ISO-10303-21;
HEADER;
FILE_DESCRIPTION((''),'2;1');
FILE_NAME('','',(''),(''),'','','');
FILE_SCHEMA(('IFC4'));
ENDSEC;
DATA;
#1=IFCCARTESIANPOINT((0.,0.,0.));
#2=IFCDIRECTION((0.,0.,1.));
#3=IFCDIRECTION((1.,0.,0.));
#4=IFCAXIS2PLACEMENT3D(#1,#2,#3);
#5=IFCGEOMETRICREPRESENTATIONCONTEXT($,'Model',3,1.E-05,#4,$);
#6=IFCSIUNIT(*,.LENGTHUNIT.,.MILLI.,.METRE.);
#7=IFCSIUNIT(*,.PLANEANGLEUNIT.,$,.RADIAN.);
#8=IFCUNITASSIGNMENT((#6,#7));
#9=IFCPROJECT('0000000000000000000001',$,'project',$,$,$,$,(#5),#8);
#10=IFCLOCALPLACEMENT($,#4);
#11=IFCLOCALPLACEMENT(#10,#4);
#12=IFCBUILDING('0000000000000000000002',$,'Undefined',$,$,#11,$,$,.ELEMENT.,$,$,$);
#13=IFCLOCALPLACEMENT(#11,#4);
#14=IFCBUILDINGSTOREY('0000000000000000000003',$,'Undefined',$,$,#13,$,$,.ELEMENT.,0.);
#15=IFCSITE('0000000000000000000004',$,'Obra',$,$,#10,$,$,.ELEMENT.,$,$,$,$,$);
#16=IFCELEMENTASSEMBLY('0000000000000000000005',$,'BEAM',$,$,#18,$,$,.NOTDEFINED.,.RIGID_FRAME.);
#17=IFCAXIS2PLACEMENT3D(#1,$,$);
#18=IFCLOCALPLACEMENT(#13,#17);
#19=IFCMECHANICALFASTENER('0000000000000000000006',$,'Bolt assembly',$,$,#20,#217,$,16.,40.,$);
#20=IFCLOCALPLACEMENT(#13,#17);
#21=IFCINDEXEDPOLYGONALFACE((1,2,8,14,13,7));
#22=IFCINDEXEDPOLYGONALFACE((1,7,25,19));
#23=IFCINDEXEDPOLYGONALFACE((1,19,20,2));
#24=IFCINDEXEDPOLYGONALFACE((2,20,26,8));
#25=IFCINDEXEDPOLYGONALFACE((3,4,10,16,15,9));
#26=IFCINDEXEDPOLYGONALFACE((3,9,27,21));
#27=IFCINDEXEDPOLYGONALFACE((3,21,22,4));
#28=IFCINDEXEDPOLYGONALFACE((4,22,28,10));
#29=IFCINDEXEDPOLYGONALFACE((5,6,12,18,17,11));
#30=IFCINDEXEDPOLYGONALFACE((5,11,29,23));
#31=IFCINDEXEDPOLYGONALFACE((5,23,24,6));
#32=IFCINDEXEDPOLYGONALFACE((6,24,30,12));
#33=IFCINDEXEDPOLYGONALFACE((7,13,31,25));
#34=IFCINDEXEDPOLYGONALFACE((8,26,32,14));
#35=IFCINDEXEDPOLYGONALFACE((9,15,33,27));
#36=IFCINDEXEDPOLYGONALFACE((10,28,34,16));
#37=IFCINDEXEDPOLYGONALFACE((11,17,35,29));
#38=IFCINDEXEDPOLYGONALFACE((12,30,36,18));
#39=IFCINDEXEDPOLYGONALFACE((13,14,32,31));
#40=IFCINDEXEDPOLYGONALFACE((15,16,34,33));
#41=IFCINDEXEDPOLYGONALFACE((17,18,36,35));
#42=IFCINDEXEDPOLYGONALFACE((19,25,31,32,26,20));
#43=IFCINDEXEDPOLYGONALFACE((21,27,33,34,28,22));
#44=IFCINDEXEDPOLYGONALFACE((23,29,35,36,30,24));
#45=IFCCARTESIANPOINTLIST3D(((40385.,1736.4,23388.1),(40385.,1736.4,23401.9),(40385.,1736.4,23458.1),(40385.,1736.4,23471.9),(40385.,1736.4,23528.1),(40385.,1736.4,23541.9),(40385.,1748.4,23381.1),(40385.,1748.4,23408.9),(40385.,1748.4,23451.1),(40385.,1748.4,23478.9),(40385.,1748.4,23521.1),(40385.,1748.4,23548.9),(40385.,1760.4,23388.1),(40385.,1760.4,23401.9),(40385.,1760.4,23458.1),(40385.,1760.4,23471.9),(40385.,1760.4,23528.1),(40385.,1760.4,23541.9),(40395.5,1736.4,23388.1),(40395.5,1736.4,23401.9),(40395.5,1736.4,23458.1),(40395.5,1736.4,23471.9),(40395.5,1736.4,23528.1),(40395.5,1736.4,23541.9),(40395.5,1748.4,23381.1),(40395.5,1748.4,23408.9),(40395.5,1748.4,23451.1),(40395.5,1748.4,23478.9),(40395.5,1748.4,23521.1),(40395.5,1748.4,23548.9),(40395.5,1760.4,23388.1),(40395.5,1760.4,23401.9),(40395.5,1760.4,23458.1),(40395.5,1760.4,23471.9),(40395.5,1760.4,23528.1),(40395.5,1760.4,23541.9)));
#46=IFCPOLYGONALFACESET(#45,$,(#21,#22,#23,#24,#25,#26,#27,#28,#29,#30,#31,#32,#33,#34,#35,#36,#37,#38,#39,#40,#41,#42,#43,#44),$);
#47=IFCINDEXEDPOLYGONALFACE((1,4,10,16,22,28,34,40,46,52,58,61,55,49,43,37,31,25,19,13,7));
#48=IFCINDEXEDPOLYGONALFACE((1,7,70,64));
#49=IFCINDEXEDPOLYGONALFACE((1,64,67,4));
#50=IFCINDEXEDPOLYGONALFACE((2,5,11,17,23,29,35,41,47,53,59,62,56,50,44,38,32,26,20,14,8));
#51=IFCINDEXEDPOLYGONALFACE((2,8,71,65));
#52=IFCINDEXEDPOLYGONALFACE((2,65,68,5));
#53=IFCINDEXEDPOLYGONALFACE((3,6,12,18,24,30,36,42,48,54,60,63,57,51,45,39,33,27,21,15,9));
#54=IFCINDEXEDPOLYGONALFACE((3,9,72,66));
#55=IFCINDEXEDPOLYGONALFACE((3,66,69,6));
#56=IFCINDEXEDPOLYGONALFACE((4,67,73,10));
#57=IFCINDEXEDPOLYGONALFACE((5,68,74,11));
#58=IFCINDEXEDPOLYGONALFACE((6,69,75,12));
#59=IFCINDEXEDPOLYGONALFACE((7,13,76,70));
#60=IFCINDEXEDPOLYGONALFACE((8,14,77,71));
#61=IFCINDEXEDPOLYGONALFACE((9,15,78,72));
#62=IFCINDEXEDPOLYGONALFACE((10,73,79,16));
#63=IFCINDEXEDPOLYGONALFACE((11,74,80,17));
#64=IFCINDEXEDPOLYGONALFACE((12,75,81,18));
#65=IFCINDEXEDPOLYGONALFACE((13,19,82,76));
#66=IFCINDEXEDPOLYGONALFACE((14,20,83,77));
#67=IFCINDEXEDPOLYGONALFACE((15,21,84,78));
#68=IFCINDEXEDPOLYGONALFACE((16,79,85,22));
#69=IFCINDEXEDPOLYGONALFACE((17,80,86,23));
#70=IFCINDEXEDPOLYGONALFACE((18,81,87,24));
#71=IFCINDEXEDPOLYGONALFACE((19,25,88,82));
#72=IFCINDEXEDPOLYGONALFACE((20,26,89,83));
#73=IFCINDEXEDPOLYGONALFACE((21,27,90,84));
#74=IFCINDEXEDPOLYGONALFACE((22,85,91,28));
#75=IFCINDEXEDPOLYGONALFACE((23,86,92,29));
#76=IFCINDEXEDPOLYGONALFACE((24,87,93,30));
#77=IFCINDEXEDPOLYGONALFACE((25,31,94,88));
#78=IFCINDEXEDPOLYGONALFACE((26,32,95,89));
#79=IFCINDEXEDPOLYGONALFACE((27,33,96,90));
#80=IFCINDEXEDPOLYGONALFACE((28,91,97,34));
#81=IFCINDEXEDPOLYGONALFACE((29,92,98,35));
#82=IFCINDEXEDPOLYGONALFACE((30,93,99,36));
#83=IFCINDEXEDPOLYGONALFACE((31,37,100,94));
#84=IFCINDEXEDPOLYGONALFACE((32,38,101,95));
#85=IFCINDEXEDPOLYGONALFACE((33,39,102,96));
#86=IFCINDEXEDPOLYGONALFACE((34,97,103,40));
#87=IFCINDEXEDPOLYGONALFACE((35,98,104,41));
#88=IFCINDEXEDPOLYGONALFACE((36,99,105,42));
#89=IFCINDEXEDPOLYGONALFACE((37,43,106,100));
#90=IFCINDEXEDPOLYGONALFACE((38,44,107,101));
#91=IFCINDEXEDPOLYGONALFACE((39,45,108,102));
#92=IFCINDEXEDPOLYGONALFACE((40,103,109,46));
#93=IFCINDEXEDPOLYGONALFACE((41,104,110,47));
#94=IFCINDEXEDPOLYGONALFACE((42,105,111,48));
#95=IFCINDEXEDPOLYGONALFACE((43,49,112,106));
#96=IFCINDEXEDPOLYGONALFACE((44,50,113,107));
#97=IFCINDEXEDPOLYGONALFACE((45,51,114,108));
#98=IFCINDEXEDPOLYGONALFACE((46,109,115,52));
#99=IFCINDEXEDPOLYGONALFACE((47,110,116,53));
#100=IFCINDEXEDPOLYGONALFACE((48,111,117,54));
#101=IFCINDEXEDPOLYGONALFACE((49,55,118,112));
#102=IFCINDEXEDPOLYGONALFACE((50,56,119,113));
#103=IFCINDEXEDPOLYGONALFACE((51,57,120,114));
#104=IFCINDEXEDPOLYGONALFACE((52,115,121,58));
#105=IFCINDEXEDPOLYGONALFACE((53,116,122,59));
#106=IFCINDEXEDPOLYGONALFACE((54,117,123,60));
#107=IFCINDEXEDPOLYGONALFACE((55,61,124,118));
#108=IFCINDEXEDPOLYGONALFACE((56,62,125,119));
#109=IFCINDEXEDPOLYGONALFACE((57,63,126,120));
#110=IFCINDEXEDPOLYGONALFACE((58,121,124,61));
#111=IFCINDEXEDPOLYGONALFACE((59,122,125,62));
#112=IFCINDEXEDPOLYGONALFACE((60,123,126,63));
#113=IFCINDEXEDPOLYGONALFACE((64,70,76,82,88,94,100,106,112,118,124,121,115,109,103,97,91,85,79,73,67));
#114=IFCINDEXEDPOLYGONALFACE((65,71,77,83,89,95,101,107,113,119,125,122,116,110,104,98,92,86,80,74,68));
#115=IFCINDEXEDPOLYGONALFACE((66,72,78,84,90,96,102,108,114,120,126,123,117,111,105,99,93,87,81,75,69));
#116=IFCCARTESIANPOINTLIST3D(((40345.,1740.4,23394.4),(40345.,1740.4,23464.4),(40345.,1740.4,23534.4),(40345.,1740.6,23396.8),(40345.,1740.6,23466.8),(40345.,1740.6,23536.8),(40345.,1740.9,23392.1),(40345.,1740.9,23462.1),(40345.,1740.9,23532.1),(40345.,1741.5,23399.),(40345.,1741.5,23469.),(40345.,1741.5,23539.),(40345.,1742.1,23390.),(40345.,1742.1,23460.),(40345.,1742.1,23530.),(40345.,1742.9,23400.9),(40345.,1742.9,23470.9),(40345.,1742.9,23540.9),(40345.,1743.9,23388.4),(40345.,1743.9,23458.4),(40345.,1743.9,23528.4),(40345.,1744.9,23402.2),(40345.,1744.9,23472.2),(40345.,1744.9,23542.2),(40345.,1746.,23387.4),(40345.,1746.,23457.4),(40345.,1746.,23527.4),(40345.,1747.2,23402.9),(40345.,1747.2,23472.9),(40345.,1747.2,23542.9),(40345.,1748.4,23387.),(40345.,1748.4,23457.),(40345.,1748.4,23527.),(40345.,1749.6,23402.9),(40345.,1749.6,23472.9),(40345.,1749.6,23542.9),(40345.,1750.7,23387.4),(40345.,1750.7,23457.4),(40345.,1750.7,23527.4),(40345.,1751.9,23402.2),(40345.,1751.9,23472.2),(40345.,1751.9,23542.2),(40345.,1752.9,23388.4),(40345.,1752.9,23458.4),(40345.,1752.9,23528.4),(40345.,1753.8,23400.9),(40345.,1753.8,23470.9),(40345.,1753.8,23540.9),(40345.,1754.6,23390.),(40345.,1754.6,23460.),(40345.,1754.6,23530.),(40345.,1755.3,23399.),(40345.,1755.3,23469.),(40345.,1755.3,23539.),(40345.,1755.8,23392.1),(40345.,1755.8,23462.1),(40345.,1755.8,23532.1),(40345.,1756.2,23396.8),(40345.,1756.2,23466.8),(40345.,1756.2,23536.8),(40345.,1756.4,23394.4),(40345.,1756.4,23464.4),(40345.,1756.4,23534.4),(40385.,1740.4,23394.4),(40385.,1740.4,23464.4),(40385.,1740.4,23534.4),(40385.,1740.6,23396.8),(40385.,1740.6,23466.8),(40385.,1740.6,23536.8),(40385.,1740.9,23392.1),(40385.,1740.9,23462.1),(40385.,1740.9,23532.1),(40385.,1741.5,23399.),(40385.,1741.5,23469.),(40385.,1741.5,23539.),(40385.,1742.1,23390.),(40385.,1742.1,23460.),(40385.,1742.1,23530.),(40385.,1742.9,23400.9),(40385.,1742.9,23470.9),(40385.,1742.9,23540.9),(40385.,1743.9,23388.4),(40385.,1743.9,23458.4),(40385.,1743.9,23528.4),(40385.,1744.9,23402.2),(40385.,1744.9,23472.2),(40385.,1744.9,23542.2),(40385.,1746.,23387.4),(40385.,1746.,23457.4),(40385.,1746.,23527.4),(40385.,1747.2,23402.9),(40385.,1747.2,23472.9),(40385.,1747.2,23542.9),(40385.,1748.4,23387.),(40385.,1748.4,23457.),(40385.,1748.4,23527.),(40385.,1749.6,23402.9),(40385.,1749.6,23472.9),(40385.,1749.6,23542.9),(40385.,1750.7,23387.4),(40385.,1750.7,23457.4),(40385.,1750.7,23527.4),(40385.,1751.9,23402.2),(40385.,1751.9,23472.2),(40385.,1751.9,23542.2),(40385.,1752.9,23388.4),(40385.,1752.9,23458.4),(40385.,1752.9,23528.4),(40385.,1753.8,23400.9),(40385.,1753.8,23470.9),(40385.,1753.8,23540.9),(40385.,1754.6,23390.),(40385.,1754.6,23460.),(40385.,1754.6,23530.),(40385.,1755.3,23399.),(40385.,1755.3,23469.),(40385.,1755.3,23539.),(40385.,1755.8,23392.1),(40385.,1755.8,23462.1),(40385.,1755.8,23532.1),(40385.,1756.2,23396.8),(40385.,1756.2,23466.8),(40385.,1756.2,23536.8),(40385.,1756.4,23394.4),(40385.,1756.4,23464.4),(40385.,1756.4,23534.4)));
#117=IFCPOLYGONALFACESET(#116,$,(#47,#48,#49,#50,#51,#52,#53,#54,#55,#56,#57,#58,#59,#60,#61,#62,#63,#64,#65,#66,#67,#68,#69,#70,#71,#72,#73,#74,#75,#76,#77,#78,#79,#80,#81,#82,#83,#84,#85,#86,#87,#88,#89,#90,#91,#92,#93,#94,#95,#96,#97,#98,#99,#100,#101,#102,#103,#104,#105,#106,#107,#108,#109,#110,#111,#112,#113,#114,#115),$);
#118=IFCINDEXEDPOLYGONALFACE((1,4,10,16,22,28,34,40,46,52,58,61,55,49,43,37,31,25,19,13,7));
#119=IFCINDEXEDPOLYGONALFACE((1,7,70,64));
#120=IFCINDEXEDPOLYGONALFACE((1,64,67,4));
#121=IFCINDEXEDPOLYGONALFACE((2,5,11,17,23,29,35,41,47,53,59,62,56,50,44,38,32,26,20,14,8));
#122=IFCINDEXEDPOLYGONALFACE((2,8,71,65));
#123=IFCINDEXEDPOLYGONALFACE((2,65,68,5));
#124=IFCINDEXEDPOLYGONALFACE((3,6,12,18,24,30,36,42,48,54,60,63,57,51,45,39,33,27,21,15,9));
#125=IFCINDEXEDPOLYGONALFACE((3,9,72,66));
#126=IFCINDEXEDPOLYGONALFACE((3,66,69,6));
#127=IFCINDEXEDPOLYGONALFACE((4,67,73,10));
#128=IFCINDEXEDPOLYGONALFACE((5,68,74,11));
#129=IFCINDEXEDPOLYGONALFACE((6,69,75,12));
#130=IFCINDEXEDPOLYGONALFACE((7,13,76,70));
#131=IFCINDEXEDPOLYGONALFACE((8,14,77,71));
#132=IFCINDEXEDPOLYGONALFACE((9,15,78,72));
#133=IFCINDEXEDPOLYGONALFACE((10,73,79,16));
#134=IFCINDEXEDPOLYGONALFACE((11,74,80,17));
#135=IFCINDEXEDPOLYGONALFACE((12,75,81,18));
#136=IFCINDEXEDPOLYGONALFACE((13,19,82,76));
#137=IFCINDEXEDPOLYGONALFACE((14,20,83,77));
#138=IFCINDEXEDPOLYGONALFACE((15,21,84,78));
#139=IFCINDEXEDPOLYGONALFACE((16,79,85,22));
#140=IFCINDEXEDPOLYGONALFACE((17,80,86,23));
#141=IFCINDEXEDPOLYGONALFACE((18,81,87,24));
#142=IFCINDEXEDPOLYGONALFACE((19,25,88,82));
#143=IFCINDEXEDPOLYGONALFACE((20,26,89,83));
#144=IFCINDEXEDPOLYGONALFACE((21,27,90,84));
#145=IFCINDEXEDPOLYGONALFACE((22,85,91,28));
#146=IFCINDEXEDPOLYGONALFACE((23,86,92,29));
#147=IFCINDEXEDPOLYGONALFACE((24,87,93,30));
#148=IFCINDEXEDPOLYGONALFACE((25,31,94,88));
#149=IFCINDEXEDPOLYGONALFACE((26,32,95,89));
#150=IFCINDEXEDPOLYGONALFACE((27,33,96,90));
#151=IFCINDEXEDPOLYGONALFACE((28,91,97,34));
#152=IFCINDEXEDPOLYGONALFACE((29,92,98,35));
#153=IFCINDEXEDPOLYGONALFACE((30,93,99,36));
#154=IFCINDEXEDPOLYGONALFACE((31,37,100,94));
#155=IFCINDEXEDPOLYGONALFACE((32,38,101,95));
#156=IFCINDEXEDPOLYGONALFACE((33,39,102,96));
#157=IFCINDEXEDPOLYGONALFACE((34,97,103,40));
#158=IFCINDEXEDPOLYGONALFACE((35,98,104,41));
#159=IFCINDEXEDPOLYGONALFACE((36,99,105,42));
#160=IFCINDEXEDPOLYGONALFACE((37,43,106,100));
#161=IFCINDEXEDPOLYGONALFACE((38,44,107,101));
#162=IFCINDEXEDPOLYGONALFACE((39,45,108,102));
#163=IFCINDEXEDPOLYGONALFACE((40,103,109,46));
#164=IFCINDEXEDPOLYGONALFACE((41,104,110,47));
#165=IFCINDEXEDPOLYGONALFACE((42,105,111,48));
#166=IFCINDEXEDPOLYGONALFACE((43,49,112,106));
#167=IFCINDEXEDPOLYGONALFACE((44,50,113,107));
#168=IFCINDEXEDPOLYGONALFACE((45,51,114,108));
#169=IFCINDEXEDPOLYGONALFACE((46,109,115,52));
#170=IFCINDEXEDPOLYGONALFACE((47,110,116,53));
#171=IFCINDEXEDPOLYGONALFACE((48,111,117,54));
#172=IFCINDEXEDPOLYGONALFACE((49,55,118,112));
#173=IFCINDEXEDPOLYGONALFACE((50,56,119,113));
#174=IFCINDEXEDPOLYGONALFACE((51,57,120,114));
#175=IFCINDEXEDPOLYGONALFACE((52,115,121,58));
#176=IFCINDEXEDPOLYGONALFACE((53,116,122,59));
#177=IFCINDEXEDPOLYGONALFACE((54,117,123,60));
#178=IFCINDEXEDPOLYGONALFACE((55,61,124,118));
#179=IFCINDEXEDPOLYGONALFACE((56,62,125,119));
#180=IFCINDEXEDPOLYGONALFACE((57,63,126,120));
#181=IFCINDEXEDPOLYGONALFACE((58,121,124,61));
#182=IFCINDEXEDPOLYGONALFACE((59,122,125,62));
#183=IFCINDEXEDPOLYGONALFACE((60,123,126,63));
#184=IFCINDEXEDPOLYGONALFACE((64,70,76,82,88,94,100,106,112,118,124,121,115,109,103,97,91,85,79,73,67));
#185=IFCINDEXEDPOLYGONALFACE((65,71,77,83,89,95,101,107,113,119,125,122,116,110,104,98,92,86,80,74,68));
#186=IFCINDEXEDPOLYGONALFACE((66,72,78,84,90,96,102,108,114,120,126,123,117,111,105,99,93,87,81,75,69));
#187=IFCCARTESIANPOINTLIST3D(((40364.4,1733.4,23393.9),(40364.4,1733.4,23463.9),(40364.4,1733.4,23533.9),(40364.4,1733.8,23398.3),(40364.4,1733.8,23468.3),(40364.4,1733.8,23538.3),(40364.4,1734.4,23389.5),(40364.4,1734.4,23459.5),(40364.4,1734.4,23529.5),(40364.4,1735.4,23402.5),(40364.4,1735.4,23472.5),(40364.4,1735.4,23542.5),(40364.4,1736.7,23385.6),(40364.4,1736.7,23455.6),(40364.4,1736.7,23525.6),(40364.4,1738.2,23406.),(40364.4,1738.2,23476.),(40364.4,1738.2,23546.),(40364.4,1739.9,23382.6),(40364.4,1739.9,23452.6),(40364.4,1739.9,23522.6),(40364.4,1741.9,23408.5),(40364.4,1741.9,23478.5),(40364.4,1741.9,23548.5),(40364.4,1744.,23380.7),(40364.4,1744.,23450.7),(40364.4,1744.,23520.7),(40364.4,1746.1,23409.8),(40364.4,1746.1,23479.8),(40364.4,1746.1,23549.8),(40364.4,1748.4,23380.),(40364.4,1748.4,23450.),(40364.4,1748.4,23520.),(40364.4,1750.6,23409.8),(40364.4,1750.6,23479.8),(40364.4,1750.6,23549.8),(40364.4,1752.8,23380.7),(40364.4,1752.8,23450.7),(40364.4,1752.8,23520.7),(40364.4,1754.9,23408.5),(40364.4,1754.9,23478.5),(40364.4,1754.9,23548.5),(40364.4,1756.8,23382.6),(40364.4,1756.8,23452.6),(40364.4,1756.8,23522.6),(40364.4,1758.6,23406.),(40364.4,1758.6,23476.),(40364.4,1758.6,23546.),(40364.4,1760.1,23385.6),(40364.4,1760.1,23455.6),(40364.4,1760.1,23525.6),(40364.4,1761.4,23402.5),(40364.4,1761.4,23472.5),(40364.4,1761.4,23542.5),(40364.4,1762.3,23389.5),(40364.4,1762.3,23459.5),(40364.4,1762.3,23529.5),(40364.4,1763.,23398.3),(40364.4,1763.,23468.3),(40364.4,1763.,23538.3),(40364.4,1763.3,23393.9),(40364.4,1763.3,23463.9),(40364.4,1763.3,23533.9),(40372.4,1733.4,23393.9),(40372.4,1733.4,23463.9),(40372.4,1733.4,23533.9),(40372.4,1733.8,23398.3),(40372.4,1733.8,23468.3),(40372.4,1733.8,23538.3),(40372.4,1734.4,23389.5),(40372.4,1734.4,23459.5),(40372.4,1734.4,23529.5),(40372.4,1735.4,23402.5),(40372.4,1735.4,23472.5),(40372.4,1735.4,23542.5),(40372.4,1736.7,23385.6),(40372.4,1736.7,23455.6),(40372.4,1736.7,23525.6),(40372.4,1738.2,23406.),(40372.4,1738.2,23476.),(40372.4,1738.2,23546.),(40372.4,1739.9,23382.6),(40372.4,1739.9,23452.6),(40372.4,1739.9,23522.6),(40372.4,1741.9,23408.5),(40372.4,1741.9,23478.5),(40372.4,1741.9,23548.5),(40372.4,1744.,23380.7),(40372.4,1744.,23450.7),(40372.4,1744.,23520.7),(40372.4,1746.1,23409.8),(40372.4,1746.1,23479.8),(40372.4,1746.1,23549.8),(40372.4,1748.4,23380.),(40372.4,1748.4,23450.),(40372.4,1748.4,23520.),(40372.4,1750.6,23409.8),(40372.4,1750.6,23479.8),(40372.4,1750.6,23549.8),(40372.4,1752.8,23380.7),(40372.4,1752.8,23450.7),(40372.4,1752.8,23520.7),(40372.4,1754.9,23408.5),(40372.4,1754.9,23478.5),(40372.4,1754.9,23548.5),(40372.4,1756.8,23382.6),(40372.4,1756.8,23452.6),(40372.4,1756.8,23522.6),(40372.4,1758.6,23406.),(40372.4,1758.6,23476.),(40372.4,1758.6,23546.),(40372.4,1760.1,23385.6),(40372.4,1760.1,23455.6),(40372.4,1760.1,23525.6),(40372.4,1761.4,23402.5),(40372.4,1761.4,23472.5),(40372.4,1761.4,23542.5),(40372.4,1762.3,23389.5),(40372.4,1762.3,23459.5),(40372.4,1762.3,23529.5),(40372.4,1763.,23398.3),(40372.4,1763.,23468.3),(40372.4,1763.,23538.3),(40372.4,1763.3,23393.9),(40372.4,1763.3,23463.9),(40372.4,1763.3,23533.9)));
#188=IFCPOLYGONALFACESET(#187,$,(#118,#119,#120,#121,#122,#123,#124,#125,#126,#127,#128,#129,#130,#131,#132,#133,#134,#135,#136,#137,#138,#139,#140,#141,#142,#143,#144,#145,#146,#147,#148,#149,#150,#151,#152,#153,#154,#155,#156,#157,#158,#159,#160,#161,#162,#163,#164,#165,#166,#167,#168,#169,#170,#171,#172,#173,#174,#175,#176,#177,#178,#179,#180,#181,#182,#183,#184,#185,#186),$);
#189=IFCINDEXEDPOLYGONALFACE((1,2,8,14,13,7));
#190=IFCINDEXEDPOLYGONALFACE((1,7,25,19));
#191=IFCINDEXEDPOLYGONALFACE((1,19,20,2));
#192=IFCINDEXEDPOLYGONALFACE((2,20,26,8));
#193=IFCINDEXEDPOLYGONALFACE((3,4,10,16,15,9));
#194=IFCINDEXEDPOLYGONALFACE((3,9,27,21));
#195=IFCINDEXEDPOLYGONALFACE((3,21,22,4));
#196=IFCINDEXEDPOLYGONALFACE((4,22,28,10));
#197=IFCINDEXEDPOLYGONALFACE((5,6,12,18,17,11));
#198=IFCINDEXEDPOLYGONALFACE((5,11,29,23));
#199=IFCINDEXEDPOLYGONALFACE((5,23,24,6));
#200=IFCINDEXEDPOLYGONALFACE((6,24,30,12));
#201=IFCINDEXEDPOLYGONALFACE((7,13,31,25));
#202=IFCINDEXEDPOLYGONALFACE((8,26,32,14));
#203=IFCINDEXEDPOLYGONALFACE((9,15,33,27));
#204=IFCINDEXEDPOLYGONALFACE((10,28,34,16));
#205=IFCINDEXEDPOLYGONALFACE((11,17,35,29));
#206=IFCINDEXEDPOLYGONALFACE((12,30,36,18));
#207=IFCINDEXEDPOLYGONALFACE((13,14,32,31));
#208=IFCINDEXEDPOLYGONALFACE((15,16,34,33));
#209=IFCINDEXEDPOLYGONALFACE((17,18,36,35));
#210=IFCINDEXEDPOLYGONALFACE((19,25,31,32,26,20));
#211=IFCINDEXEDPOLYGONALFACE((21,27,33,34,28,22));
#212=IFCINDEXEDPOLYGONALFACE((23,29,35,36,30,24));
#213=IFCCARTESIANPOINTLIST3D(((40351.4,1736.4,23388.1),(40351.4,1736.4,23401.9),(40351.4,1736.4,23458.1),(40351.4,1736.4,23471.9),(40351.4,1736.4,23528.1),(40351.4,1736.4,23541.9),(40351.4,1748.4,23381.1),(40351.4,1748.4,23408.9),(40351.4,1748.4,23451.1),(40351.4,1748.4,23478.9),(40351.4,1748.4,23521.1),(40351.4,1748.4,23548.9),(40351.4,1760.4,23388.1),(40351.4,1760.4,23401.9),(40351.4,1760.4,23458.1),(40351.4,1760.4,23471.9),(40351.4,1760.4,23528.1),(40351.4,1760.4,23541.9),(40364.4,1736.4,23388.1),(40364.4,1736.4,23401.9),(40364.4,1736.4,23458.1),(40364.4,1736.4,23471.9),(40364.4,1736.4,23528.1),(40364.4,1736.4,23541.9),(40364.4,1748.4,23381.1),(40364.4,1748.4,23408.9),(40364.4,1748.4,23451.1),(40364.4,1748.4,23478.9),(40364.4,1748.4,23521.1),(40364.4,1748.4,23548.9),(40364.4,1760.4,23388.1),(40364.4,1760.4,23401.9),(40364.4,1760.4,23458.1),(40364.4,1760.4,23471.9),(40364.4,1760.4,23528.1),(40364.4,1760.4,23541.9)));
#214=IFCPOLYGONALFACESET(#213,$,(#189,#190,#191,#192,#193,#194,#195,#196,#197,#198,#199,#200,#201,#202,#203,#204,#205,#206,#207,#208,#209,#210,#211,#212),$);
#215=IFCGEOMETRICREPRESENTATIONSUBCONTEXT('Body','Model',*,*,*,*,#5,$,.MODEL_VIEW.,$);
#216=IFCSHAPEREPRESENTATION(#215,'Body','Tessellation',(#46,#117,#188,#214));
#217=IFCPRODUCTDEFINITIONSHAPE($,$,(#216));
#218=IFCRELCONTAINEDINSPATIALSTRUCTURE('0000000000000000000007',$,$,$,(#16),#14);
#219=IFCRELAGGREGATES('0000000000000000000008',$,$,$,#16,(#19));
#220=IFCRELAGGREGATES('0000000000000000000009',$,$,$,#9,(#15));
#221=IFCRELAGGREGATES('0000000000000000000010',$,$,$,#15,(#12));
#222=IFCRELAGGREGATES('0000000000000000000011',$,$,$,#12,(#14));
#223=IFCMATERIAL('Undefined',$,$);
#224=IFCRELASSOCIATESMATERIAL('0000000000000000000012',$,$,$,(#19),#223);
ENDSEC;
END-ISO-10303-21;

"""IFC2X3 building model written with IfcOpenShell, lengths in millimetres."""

from ifc_helpers import new_model, si_unit, frame, origin_with_axes, origin_2d_with_axis, place, context, subcontext, project, spatial, polyline, circle, outline, extrude, source, transform, mapped, material, element, aggregate, save


model = new_model("IFC2X3")

# Units and contexts
model_context = context("Model", 3, precision=1e-05, world=origin_with_axes())
body_context = subcontext(model_context, "Body", "Model", "MODEL_VIEW")
ifc_project = project(units=[si_unit("LENGTHUNIT", "METRE", prefix="MILLI"), si_unit("PLANEANGLEUNIT", "RADIAN")], contexts=[model_context])

# Site, building, storey
site_placement = place(None, origin_with_axes())
site = spatial("IfcSite", under=ifc_project, at=site_placement, Name="Obra", CompositionType="ELEMENT")
building_placement = place(site_placement, origin_with_axes())
building = spatial("IfcBuilding", under=site, at=building_placement, Name="Undefined", CompositionType="ELEMENT")
storey_placement = place(building_placement, origin_with_axes())
storey = spatial("IfcBuildingStorey", under=building, at=storey_placement, Name="Undefined", CompositionType="ELEMENT", Elevation=0.0)

# Element assembly
assembly_1_placement = place(storey_placement, origin_with_axes())
assembly_1 = element("IfcElementAssembly", 1, at=assembly_1_placement, inside=storey, Name="BEAM", AssemblyPlace="NOTDEFINED", PredefinedType="RIGID_FRAME")

# Shared definitions
ifc_material_1 = material(Name="Undefined")

# Mechanical fastener
shared_shape_1 = source(origin_with_axes(), body_context, "Body", "SweptSolid", [
    extrude(outline(polyline([(13.9, 0.0), (6.9, 12.0), (-6.9, 12.0), (-13.9, 0.0), (-6.9, -12.0), (6.9, -12.0), (13.9, 0.0)])), frame((0.0, -13.9, 0.0), z_axis=(0.0, 1.0, 0.0), x_axis=(1.0, 0.0, 0.0)), (0.0, 0.0, 1.0), 10.6),
    extrude(circle(Radius=8.0, at=origin_2d_with_axis()), frame((0.0, -3.3, 0.0), z_axis=(0.0, 1.0, 0.0), x_axis=(1.0, 0.0, 0.0)), (0.0, 0.0, 1.0), 40.0),
    extrude(circle(Radius=15.0, at=origin_2d_with_axis()), frame((0.0, 9.3, 0.0), z_axis=(0.0, 1.0, 0.0), x_axis=(1.0, 0.0, 0.0)), (0.0, 0.0, 1.0), 8.0),
    extrude(outline(polyline([(13.9, 0.0), (6.9, 12.0), (-6.9, 12.0), (-13.9, 0.0), (-6.9, -12.0), (6.9, -12.0), (13.9, 0.0)])), frame((0.0, 17.3, 0.0), z_axis=(0.0, 1.0, 0.0), x_axis=(1.0, 0.0, 0.0)), (0.0, 0.0, 1.0), 13.0),
])
mechanical_fastener_1_placement = place(assembly_1_placement, frame((40381.7, 1708.4, 23570.0), z_axis=(0.0, 1.0, 0.0), x_axis=(0.0, 0.0, -1.0)))
mechanical_fastener_1 = element("IfcMechanicalFastener", 2, at=mechanical_fastener_1_placement, material=ifc_material_1, Name="Bolt assembly", NominalDiameter=16.0, NominalLength=40.0, context=body_context, shape_type="MappedRepresentation", body=[
    mapped(shared_shape_1, transform((35.0, 0.0, 40.0))),
    mapped(shared_shape_1, transform((105.0, 0.0, 40.0))),
    mapped(shared_shape_1, transform((175.0, 0.0, 40.0))),
])

aggregate(assembly_1, [mechanical_fastener_1])

save(model, "model.ifc")
